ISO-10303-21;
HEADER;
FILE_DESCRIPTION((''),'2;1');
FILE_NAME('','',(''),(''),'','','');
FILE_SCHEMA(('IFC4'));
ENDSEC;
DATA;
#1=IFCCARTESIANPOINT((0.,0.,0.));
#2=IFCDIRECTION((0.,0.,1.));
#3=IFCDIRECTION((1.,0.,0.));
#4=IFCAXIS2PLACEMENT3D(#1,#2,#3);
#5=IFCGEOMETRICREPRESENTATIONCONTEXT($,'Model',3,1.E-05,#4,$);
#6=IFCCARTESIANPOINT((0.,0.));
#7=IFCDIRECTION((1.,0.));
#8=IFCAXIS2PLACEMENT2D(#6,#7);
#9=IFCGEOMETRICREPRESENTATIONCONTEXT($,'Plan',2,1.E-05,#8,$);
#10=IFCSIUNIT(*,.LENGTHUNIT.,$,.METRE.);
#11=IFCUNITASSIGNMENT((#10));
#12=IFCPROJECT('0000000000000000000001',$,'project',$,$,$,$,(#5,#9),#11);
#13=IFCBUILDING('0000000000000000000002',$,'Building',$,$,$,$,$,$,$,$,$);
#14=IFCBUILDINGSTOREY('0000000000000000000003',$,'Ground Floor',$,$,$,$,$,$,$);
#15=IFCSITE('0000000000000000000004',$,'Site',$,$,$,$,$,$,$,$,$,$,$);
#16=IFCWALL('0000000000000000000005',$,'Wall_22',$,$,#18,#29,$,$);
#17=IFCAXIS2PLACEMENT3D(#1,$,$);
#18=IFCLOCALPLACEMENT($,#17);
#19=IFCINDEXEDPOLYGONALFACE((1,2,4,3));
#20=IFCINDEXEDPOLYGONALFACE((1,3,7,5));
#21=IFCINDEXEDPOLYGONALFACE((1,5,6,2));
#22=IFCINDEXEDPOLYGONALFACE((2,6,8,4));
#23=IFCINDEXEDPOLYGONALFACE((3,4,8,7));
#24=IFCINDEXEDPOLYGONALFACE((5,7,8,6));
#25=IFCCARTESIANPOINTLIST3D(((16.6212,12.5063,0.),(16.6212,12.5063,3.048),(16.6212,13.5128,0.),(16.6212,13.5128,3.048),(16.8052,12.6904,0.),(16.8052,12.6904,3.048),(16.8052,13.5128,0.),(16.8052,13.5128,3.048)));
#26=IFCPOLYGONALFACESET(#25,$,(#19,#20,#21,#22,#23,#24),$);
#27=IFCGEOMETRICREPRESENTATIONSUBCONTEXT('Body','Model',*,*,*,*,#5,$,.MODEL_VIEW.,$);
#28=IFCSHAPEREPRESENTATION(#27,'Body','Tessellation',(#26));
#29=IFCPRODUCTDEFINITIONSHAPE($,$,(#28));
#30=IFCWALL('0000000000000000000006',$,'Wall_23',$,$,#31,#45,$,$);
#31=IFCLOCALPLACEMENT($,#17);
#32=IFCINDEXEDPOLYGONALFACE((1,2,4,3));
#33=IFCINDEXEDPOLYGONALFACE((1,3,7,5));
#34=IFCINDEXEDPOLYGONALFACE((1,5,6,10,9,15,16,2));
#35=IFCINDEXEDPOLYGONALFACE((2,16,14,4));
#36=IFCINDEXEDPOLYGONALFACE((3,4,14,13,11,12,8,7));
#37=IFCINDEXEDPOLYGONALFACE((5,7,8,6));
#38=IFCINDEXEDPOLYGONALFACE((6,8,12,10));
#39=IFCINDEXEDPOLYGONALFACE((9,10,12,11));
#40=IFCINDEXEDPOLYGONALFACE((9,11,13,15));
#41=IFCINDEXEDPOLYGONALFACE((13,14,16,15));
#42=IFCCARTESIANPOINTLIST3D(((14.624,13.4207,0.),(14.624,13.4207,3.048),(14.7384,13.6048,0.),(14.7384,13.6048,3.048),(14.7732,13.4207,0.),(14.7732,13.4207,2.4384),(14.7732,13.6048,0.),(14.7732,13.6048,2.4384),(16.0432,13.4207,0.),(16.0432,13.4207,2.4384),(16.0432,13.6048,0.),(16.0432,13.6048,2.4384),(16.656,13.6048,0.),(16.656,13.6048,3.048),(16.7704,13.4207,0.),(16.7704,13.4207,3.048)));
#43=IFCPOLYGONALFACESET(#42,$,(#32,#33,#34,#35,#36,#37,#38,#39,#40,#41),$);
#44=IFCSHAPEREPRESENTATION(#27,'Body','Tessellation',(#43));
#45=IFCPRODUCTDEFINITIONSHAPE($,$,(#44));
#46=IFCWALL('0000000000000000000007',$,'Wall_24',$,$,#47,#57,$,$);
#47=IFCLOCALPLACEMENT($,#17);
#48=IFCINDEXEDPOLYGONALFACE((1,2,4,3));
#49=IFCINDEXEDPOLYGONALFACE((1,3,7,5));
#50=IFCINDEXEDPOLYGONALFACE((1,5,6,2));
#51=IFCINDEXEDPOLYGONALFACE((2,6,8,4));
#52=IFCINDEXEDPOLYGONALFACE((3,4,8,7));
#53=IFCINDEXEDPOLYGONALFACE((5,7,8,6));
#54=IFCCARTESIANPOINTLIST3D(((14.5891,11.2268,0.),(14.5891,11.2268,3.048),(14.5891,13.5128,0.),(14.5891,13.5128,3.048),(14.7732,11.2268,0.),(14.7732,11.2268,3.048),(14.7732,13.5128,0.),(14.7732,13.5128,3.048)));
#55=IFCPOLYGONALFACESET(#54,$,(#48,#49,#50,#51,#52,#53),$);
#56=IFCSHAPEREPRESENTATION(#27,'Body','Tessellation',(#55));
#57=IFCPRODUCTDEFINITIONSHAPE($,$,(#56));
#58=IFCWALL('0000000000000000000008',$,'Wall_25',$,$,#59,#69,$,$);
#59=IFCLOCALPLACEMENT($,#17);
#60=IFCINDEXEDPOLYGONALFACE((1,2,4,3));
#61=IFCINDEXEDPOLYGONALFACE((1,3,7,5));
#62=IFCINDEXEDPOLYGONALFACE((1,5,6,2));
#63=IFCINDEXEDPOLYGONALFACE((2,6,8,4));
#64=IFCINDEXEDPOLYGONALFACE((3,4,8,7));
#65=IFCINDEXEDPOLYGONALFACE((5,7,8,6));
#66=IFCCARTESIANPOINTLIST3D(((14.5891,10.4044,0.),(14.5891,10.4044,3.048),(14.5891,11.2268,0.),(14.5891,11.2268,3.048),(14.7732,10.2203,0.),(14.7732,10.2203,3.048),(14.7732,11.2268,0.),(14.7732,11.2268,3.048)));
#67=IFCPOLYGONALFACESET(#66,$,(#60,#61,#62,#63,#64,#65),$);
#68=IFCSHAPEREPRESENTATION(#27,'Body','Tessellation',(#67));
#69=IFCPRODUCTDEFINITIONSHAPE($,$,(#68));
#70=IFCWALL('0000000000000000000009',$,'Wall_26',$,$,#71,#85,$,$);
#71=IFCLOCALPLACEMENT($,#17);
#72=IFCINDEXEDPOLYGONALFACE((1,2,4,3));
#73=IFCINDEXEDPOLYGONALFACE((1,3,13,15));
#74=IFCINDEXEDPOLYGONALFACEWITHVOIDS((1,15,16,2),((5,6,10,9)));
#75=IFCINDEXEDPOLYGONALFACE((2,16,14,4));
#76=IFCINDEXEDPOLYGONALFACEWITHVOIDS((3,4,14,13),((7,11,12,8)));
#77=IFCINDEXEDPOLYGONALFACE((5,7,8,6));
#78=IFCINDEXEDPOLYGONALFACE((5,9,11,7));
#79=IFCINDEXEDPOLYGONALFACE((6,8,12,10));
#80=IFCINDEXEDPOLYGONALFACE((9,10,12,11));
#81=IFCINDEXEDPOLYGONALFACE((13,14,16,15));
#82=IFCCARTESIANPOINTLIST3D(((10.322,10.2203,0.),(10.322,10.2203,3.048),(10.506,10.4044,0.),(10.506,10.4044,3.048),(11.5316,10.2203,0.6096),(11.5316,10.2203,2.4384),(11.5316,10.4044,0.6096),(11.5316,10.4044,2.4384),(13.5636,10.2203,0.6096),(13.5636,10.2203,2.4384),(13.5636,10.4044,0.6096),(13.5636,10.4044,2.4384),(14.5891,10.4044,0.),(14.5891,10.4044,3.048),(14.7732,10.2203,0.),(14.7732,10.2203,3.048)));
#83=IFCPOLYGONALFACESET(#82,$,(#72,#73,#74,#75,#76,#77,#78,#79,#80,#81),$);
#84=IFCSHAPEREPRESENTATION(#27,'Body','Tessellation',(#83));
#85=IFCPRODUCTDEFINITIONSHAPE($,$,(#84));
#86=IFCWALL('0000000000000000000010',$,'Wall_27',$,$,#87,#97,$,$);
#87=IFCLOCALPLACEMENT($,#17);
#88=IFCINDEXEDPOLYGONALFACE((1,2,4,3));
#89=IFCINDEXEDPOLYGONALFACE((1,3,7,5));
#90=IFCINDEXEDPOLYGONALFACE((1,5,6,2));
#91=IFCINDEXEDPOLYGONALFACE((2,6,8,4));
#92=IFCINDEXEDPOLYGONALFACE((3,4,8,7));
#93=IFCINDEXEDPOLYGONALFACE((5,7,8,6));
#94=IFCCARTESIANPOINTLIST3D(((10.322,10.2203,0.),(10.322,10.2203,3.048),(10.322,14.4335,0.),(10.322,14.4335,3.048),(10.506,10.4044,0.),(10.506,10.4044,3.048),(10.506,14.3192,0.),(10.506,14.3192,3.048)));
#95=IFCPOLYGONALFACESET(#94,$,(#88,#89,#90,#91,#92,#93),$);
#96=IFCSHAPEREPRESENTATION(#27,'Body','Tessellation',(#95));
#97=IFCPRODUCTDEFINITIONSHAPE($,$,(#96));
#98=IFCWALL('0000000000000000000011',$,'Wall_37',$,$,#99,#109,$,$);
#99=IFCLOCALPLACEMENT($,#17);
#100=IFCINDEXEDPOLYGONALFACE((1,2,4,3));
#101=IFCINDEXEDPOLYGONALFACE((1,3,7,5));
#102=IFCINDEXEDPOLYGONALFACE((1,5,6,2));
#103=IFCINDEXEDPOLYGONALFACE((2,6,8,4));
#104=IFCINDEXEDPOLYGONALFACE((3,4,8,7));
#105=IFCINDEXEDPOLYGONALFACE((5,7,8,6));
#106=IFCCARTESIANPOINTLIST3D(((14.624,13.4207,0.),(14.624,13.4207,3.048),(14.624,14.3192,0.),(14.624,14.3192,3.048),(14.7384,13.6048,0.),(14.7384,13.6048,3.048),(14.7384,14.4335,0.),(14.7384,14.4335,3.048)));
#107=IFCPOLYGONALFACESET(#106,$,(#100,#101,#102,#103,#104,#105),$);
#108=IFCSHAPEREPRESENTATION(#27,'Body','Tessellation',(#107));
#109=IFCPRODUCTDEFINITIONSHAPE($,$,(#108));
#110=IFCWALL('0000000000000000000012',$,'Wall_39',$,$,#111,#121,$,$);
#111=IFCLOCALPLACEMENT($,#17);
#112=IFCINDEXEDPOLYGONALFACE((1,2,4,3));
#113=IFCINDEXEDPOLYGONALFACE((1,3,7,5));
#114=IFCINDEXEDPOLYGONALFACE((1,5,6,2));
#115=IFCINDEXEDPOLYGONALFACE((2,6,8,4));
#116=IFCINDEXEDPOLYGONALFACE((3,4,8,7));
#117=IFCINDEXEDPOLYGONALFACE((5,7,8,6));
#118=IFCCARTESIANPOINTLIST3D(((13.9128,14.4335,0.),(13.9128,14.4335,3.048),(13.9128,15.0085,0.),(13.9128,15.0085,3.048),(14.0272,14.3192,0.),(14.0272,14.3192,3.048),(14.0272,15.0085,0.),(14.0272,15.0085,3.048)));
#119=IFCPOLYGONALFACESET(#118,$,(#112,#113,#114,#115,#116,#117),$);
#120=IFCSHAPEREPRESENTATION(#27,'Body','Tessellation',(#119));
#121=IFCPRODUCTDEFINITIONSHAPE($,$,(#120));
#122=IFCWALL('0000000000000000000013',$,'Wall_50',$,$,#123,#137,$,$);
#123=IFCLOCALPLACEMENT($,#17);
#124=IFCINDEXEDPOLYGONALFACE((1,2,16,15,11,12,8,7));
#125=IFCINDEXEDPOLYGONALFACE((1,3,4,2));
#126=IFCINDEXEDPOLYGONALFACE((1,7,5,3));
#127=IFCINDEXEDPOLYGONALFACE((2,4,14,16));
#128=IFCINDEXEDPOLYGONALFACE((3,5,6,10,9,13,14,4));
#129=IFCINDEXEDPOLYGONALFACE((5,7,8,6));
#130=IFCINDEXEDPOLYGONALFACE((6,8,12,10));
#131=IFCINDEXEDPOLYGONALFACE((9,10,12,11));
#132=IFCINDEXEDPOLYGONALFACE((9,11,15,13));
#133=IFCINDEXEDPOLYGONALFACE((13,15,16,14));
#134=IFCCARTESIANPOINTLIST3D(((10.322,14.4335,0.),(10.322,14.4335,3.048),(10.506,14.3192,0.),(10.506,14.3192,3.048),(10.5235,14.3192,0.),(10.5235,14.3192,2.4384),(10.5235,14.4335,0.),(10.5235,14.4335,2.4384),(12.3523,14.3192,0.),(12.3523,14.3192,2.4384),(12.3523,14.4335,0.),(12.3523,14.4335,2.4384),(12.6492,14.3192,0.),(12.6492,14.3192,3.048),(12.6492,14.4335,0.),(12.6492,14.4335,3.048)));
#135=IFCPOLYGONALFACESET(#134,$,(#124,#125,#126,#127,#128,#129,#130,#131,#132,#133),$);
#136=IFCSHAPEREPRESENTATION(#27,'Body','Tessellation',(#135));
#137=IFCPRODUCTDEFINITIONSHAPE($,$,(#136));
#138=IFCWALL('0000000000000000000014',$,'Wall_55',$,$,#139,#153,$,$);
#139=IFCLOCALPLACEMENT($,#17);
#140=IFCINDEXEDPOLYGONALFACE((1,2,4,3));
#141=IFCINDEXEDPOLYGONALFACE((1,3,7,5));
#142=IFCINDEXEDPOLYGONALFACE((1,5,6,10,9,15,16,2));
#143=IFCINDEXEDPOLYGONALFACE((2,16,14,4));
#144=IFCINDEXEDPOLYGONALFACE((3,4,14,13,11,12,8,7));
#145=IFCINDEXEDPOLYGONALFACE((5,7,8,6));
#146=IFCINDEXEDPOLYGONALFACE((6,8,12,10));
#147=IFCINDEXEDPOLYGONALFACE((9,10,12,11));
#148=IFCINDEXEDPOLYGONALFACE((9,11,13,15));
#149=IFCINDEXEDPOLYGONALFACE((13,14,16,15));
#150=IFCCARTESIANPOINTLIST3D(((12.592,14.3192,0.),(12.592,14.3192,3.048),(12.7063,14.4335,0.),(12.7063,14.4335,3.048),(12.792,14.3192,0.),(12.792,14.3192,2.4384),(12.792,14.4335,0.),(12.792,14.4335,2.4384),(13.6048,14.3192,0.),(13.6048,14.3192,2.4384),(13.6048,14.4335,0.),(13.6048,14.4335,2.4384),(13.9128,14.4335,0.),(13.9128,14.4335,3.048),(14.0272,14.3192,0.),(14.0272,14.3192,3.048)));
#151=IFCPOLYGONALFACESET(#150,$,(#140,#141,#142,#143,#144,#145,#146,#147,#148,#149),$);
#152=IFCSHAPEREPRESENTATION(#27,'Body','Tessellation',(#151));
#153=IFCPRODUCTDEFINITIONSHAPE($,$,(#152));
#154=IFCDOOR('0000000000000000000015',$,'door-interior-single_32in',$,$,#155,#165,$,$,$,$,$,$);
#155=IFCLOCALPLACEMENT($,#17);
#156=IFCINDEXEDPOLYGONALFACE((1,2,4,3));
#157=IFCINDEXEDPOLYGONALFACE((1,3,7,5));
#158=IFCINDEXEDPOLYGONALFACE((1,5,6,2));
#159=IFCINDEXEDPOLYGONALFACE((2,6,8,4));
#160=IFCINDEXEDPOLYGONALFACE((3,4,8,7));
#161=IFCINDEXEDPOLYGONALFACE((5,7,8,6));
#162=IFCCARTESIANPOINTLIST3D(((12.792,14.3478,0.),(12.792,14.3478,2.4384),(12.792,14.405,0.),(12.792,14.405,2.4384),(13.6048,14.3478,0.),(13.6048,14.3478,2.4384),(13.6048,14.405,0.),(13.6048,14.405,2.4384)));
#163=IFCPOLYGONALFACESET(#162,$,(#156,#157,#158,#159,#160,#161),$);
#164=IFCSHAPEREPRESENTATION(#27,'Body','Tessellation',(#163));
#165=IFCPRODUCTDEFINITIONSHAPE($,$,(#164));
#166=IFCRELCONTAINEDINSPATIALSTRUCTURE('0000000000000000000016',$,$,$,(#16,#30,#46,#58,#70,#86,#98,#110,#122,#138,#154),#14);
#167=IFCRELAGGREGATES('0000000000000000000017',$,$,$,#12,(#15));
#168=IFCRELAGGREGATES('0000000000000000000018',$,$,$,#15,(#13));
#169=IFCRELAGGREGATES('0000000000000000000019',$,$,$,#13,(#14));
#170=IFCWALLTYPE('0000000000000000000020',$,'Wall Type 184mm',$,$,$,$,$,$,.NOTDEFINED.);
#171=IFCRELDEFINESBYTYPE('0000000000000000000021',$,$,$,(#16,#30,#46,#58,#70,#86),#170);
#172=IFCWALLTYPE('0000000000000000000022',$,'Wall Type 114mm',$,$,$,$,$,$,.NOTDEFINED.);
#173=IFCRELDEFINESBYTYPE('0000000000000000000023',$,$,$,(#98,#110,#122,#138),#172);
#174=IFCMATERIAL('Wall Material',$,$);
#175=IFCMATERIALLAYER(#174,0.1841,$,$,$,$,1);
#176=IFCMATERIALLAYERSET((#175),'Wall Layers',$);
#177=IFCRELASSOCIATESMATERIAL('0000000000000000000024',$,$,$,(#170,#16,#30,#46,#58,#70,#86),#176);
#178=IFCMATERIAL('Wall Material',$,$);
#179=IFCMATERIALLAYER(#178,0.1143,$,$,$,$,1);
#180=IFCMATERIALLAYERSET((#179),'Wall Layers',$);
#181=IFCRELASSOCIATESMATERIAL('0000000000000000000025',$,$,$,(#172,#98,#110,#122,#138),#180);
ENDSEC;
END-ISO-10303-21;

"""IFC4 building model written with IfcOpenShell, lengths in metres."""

from ifc_helpers import new_model, si_unit, frame, origin_with_axes, origin_2d_with_axis, place, context, subcontext, project, spatial, line, indexed_curve, rectangle, outline, extrude, material, layer, layer_set, layer_usage, type_object, element, fill, save


model = new_model("IFC4")

# Units and contexts
model_context = context("Model", 3, precision=1e-05, world=origin_with_axes())
plan_context = context("Plan", 2, precision=1e-05, world=origin_2d_with_axis())
body_context = subcontext(model_context, "Body", "Model", "MODEL_VIEW")
ifc_project = project(units=[si_unit("LENGTHUNIT", "METRE")], contexts=[model_context, plan_context])

# Site, building, storey
site = spatial("IfcSite", under=ifc_project, Name="Site")
building = spatial("IfcBuilding", under=site, Name="Building")
storey = spatial("IfcBuildingStorey", under=building, Name="Ground Floor")

# Shared definitions
ifc_material_1 = material(Name="Wall Material")
ifc_layer_1 = layer(ifc_material_1, 0.1841, Priority=1)
ifc_layer_set_1 = layer_set([ifc_layer_1], Name="Wall Layers")
wall_type_1 = type_object("IfcWallType", Name="Wall Type 184mm", PredefinedType="NOTDEFINED", material=ifc_layer_set_1)

# Wall
ifc_layer_usage_1 = layer_usage(ifc_layer_set_1, "AXIS2", "POSITIVE", -0.0921)
wall_1_placement = place(None, frame((16.7132, 12.5984, 0.0), z_axis=(0.0, 0.0, 1.0), x_axis=(0.0, 1.0, 0.0)))
element("IfcWall", 1, at=wall_1_placement, inside=storey, type_object=wall_type_1, material=ifc_layer_usage_1, Name="Wall_22", context=body_context, shape_type="SweptSolid", body=[
    extrude(outline(indexed_curve([(0.0921, -0.0921), (-0.0921, 0.0921), (0.9144, 0.0921), (0.9144, -0.0921)], segments=[line(1, 2, 3, 4, 1)])), origin_with_axes(), (0.0, 0.0, 1.0), 3.048),
])

# Wall, opening
ifc_layer_usage_2 = layer_usage(ifc_layer_set_1, "AXIS2", "POSITIVE", -0.0921)
wall_2_placement = place(None, frame((16.7132, 13.5128, 0.0), z_axis=(0.0, 0.0, 1.0), x_axis=(-1.0, 0.0, 0.0)))
wall_2 = element("IfcWall", 2, at=wall_2_placement, inside=storey, type_object=wall_type_1, material=ifc_layer_usage_2, Name="Wall_23", context=body_context, shape_type="SweptSolid", body=[
    extrude(outline(indexed_curve([(0.0572, -0.0921), (-0.0572, 0.0921), (2.0892, 0.0921), (1.9749, -0.0921)], segments=[line(1, 2, 3, 4, 1)])), origin_with_axes(), (0.0, 0.0, 1.0), 3.048),
])
opening_1_placement = place(wall_2_placement, frame((1.305, 0.0, 0.0), z_axis=(0.0, 0.0, 1.0), x_axis=(1.0, 0.0, 0.0)))
element("IfcOpeningElement", 3, at=opening_1_placement, cuts=wall_2, context=body_context, shape_type="SweptSolid", body=[
    extrude(rectangle(XDim=1.27, YDim=0.5524), None, (0.0, 0.0, 1.0), 2.4384),
])

# Walls
ifc_layer_usage_3 = layer_usage(ifc_layer_set_1, "AXIS2", "POSITIVE", -0.0921)
wall_3_placement = place(None, frame((14.6812, 13.5128, 0.0), z_axis=(0.0, 0.0, 1.0), x_axis=(0.0, -1.0, 0.0)))
element("IfcWall", 4, at=wall_3_placement, inside=storey, type_object=wall_type_1, material=ifc_layer_usage_3, Name="Wall_24", context=body_context, shape_type="SweptSolid", body=[
    extrude(outline(indexed_curve([(0.0, -0.0921), (0.0, 0.0921), (2.286, 0.0921), (2.286, -0.0921)], segments=[line(1, 2, 3, 4, 1)])), origin_with_axes(), (0.0, 0.0, 1.0), 3.048),
])
ifc_layer_usage_4 = layer_usage(ifc_layer_set_1, "AXIS2", "POSITIVE", -0.0921)
wall_4_placement = place(None, frame((14.6812, 11.2268, 0.0), z_axis=(0.0, 0.0, 1.0), x_axis=(0.0, -1.0, 0.0)))
element("IfcWall", 5, at=wall_4_placement, inside=storey, type_object=wall_type_1, material=ifc_layer_usage_4, Name="Wall_25", context=body_context, shape_type="SweptSolid", body=[
    extrude(outline(indexed_curve([(0.0, -0.0921), (0.0, 0.0921), (1.0065, 0.0921), (0.8224, -0.0921)], segments=[line(1, 2, 3, 4, 1)])), origin_with_axes(), (0.0, 0.0, 1.0), 3.048),
])

# Wall, opening
ifc_layer_usage_5 = layer_usage(ifc_layer_set_1, "AXIS2", "POSITIVE", -0.0921)
wall_5_placement = place(None, frame((14.6812, 10.3124, 0.0), z_axis=(0.0, 0.0, 1.0), x_axis=(-1.0, 0.0, 0.0)))
wall_5 = element("IfcWall", 6, at=wall_5_placement, inside=storey, type_object=wall_type_1, material=ifc_layer_usage_5, Name="Wall_26", context=body_context, shape_type="SweptSolid", body=[
    extrude(outline(indexed_curve([(0.0921, -0.0921), (-0.0921, 0.0921), (4.3592, 0.0921), (4.1751, -0.0921)], segments=[line(1, 2, 3, 4, 1)])), origin_with_axes(), (0.0, 0.0, 1.0), 3.048),
])
opening_2_placement = place(wall_5_placement, frame((2.1336, 0.0, 0.6096), z_axis=(0.0, 0.0, 1.0), x_axis=(1.0, 0.0, 0.0)))
element("IfcOpeningElement", 7, at=opening_2_placement, cuts=wall_5, context=body_context, shape_type="SweptSolid", body=[
    extrude(rectangle(XDim=2.032, YDim=0.5524), None, (0.0, 0.0, 1.0), 1.8288),
])

# Walls
ifc_layer_usage_6 = layer_usage(ifc_layer_set_1, "AXIS2", "POSITIVE", -0.0921)
wall_6_placement = place(None, frame((10.414, 10.3124, 0.0), z_axis=(0.0, 0.0, 1.0), x_axis=(0.0, 1.0, 0.0)))
element("IfcWall", 8, at=wall_6_placement, inside=storey, type_object=wall_type_1, material=ifc_layer_usage_6, Name="Wall_27", context=body_context, shape_type="SweptSolid", body=[
    extrude(outline(indexed_curve([(0.0921, -0.0921), (-0.0921, 0.0921), (4.1211, 0.0921), (4.0068, -0.0921)], segments=[line(1, 2, 3, 4, 1)])), origin_with_axes(), (0.0, 0.0, 1.0), 3.048),
])
ifc_material_2 = material(Name="Wall Material")
ifc_layer_2 = layer(ifc_material_2, 0.1143, Priority=1)
ifc_layer_set_2 = layer_set([ifc_layer_2], Name="Wall Layers")
ifc_layer_usage_7 = layer_usage(ifc_layer_set_2, "AXIS2", "POSITIVE", -0.0571)
wall_type_2 = type_object("IfcWallType", Name="Wall Type 114mm", PredefinedType="NOTDEFINED", material=ifc_layer_set_2)
wall_7_placement = place(None, frame((14.6812, 13.5128, 0.0), z_axis=(0.0, 0.0, 1.0), x_axis=(0.0, 1.0, 0.0)))
element("IfcWall", 9, at=wall_7_placement, inside=storey, type_object=wall_type_2, material=ifc_layer_usage_7, Name="Wall_37", context=body_context, shape_type="SweptSolid", body=[
    extrude(outline(indexed_curve([(0.0921, -0.0571), (-0.0921, 0.0571), (0.8065, 0.0571), (0.9208, -0.0571)], segments=[line(1, 2, 3, 4, 1)])), origin_with_axes(), (0.0, 0.0, 1.0), 3.048),
])
ifc_layer_usage_8 = layer_usage(ifc_layer_set_2, "AXIS2", "POSITIVE", -0.0571)
wall_8_placement = place(None, frame((13.97, 14.3764, 0.0), z_axis=(0.0, 0.0, 1.0), x_axis=(0.0, 1.0, 0.0)))
element("IfcWall", 10, at=wall_8_placement, inside=storey, type_object=wall_type_2, material=ifc_layer_usage_8, Name="Wall_39", context=body_context, shape_type="SweptSolid", body=[
    extrude(outline(indexed_curve([(-0.0572, -0.0571), (0.0572, 0.0571), (0.6321, 0.0571), (0.6321, -0.0571)], segments=[line(1, 2, 3, 4, 1)])), origin_with_axes(), (0.0, 0.0, 1.0), 3.048),
])

# Wall, opening
ifc_layer_usage_9 = layer_usage(ifc_layer_set_2, "AXIS2", "POSITIVE", -0.0571)
wall_9_placement = place(None, frame((12.6492, 14.3764, 0.0), z_axis=(0.0, 0.0, 1.0), x_axis=(-1.0, 0.0, 0.0)))
wall_9 = element("IfcWall", 11, at=wall_9_placement, inside=storey, type_object=wall_type_2, material=ifc_layer_usage_9, Name="Wall_50", context=body_context, shape_type="SweptSolid", body=[
    extrude(outline(indexed_curve([(0.0, -0.0571), (0.0, 0.0571), (2.1431, 0.0571), (2.3272, -0.0571)], segments=[line(1, 2, 3, 4, 1)])), origin_with_axes(), (0.0, 0.0, 1.0), 3.048),
])
opening_3_placement = place(wall_9_placement, frame((1.2113, 0.0, 0.0), z_axis=(0.0, 0.0, 1.0), x_axis=(1.0, 0.0, 0.0)))
element("IfcOpeningElement", 12, at=opening_3_placement, cuts=wall_9, context=body_context, shape_type="SweptSolid", body=[
    extrude(rectangle(XDim=1.8288, YDim=0.5), None, (0.0, 0.0, 1.0), 2.4384),
])

# Wall, opening, door
ifc_layer_usage_10 = layer_usage(ifc_layer_set_2, "AXIS2", "POSITIVE", -0.0571)
wall_10_placement = place(None, frame((13.97, 14.3764, 0.0), z_axis=(0.0, 0.0, 1.0), x_axis=(-1.0, 0.0, 0.0)))
wall_10 = element("IfcWall", 13, at=wall_10_placement, inside=storey, type_object=wall_type_2, material=ifc_layer_usage_10, Name="Wall_55", context=body_context, shape_type="SweptSolid", body=[
    extrude(outline(indexed_curve([(0.0572, -0.0571), (-0.0572, 0.0571), (1.378, 0.0571), (1.2636, -0.0571)], segments=[line(1, 2, 3, 4, 1)])), origin_with_axes(), (0.0, 0.0, 1.0), 3.048),
])
opening_4_placement = place(wall_10_placement, frame((0.7716, 0.0, 0.0), z_axis=(0.0, 0.0, 1.0), x_axis=(1.0, 0.0, 0.0)))
opening_4 = element("IfcOpeningElement", 14, at=opening_4_placement, cuts=wall_10, context=body_context, shape_type="SweptSolid", body=[
    extrude(rectangle(XDim=0.8128, YDim=0.5), None, (0.0, 0.0, 1.0), 2.4384),
])
door_placement = place(None, frame((13.1984, 14.3764, 0.0), z_axis=(0.0, 0.0, 1.0), x_axis=(1.0, 0.0, 0.0)))
door = element("IfcDoor", 15, at=door_placement, inside=storey, Name="door-interior-single_32in", context=body_context, shape_type="SweptSolid", body=[
    extrude(rectangle(XDim=0.8128, YDim=0.0571), None, (0.0, 0.0, 1.0), 2.4384),
])
fill(opening_4, door)

save(model, "model.ifc")
